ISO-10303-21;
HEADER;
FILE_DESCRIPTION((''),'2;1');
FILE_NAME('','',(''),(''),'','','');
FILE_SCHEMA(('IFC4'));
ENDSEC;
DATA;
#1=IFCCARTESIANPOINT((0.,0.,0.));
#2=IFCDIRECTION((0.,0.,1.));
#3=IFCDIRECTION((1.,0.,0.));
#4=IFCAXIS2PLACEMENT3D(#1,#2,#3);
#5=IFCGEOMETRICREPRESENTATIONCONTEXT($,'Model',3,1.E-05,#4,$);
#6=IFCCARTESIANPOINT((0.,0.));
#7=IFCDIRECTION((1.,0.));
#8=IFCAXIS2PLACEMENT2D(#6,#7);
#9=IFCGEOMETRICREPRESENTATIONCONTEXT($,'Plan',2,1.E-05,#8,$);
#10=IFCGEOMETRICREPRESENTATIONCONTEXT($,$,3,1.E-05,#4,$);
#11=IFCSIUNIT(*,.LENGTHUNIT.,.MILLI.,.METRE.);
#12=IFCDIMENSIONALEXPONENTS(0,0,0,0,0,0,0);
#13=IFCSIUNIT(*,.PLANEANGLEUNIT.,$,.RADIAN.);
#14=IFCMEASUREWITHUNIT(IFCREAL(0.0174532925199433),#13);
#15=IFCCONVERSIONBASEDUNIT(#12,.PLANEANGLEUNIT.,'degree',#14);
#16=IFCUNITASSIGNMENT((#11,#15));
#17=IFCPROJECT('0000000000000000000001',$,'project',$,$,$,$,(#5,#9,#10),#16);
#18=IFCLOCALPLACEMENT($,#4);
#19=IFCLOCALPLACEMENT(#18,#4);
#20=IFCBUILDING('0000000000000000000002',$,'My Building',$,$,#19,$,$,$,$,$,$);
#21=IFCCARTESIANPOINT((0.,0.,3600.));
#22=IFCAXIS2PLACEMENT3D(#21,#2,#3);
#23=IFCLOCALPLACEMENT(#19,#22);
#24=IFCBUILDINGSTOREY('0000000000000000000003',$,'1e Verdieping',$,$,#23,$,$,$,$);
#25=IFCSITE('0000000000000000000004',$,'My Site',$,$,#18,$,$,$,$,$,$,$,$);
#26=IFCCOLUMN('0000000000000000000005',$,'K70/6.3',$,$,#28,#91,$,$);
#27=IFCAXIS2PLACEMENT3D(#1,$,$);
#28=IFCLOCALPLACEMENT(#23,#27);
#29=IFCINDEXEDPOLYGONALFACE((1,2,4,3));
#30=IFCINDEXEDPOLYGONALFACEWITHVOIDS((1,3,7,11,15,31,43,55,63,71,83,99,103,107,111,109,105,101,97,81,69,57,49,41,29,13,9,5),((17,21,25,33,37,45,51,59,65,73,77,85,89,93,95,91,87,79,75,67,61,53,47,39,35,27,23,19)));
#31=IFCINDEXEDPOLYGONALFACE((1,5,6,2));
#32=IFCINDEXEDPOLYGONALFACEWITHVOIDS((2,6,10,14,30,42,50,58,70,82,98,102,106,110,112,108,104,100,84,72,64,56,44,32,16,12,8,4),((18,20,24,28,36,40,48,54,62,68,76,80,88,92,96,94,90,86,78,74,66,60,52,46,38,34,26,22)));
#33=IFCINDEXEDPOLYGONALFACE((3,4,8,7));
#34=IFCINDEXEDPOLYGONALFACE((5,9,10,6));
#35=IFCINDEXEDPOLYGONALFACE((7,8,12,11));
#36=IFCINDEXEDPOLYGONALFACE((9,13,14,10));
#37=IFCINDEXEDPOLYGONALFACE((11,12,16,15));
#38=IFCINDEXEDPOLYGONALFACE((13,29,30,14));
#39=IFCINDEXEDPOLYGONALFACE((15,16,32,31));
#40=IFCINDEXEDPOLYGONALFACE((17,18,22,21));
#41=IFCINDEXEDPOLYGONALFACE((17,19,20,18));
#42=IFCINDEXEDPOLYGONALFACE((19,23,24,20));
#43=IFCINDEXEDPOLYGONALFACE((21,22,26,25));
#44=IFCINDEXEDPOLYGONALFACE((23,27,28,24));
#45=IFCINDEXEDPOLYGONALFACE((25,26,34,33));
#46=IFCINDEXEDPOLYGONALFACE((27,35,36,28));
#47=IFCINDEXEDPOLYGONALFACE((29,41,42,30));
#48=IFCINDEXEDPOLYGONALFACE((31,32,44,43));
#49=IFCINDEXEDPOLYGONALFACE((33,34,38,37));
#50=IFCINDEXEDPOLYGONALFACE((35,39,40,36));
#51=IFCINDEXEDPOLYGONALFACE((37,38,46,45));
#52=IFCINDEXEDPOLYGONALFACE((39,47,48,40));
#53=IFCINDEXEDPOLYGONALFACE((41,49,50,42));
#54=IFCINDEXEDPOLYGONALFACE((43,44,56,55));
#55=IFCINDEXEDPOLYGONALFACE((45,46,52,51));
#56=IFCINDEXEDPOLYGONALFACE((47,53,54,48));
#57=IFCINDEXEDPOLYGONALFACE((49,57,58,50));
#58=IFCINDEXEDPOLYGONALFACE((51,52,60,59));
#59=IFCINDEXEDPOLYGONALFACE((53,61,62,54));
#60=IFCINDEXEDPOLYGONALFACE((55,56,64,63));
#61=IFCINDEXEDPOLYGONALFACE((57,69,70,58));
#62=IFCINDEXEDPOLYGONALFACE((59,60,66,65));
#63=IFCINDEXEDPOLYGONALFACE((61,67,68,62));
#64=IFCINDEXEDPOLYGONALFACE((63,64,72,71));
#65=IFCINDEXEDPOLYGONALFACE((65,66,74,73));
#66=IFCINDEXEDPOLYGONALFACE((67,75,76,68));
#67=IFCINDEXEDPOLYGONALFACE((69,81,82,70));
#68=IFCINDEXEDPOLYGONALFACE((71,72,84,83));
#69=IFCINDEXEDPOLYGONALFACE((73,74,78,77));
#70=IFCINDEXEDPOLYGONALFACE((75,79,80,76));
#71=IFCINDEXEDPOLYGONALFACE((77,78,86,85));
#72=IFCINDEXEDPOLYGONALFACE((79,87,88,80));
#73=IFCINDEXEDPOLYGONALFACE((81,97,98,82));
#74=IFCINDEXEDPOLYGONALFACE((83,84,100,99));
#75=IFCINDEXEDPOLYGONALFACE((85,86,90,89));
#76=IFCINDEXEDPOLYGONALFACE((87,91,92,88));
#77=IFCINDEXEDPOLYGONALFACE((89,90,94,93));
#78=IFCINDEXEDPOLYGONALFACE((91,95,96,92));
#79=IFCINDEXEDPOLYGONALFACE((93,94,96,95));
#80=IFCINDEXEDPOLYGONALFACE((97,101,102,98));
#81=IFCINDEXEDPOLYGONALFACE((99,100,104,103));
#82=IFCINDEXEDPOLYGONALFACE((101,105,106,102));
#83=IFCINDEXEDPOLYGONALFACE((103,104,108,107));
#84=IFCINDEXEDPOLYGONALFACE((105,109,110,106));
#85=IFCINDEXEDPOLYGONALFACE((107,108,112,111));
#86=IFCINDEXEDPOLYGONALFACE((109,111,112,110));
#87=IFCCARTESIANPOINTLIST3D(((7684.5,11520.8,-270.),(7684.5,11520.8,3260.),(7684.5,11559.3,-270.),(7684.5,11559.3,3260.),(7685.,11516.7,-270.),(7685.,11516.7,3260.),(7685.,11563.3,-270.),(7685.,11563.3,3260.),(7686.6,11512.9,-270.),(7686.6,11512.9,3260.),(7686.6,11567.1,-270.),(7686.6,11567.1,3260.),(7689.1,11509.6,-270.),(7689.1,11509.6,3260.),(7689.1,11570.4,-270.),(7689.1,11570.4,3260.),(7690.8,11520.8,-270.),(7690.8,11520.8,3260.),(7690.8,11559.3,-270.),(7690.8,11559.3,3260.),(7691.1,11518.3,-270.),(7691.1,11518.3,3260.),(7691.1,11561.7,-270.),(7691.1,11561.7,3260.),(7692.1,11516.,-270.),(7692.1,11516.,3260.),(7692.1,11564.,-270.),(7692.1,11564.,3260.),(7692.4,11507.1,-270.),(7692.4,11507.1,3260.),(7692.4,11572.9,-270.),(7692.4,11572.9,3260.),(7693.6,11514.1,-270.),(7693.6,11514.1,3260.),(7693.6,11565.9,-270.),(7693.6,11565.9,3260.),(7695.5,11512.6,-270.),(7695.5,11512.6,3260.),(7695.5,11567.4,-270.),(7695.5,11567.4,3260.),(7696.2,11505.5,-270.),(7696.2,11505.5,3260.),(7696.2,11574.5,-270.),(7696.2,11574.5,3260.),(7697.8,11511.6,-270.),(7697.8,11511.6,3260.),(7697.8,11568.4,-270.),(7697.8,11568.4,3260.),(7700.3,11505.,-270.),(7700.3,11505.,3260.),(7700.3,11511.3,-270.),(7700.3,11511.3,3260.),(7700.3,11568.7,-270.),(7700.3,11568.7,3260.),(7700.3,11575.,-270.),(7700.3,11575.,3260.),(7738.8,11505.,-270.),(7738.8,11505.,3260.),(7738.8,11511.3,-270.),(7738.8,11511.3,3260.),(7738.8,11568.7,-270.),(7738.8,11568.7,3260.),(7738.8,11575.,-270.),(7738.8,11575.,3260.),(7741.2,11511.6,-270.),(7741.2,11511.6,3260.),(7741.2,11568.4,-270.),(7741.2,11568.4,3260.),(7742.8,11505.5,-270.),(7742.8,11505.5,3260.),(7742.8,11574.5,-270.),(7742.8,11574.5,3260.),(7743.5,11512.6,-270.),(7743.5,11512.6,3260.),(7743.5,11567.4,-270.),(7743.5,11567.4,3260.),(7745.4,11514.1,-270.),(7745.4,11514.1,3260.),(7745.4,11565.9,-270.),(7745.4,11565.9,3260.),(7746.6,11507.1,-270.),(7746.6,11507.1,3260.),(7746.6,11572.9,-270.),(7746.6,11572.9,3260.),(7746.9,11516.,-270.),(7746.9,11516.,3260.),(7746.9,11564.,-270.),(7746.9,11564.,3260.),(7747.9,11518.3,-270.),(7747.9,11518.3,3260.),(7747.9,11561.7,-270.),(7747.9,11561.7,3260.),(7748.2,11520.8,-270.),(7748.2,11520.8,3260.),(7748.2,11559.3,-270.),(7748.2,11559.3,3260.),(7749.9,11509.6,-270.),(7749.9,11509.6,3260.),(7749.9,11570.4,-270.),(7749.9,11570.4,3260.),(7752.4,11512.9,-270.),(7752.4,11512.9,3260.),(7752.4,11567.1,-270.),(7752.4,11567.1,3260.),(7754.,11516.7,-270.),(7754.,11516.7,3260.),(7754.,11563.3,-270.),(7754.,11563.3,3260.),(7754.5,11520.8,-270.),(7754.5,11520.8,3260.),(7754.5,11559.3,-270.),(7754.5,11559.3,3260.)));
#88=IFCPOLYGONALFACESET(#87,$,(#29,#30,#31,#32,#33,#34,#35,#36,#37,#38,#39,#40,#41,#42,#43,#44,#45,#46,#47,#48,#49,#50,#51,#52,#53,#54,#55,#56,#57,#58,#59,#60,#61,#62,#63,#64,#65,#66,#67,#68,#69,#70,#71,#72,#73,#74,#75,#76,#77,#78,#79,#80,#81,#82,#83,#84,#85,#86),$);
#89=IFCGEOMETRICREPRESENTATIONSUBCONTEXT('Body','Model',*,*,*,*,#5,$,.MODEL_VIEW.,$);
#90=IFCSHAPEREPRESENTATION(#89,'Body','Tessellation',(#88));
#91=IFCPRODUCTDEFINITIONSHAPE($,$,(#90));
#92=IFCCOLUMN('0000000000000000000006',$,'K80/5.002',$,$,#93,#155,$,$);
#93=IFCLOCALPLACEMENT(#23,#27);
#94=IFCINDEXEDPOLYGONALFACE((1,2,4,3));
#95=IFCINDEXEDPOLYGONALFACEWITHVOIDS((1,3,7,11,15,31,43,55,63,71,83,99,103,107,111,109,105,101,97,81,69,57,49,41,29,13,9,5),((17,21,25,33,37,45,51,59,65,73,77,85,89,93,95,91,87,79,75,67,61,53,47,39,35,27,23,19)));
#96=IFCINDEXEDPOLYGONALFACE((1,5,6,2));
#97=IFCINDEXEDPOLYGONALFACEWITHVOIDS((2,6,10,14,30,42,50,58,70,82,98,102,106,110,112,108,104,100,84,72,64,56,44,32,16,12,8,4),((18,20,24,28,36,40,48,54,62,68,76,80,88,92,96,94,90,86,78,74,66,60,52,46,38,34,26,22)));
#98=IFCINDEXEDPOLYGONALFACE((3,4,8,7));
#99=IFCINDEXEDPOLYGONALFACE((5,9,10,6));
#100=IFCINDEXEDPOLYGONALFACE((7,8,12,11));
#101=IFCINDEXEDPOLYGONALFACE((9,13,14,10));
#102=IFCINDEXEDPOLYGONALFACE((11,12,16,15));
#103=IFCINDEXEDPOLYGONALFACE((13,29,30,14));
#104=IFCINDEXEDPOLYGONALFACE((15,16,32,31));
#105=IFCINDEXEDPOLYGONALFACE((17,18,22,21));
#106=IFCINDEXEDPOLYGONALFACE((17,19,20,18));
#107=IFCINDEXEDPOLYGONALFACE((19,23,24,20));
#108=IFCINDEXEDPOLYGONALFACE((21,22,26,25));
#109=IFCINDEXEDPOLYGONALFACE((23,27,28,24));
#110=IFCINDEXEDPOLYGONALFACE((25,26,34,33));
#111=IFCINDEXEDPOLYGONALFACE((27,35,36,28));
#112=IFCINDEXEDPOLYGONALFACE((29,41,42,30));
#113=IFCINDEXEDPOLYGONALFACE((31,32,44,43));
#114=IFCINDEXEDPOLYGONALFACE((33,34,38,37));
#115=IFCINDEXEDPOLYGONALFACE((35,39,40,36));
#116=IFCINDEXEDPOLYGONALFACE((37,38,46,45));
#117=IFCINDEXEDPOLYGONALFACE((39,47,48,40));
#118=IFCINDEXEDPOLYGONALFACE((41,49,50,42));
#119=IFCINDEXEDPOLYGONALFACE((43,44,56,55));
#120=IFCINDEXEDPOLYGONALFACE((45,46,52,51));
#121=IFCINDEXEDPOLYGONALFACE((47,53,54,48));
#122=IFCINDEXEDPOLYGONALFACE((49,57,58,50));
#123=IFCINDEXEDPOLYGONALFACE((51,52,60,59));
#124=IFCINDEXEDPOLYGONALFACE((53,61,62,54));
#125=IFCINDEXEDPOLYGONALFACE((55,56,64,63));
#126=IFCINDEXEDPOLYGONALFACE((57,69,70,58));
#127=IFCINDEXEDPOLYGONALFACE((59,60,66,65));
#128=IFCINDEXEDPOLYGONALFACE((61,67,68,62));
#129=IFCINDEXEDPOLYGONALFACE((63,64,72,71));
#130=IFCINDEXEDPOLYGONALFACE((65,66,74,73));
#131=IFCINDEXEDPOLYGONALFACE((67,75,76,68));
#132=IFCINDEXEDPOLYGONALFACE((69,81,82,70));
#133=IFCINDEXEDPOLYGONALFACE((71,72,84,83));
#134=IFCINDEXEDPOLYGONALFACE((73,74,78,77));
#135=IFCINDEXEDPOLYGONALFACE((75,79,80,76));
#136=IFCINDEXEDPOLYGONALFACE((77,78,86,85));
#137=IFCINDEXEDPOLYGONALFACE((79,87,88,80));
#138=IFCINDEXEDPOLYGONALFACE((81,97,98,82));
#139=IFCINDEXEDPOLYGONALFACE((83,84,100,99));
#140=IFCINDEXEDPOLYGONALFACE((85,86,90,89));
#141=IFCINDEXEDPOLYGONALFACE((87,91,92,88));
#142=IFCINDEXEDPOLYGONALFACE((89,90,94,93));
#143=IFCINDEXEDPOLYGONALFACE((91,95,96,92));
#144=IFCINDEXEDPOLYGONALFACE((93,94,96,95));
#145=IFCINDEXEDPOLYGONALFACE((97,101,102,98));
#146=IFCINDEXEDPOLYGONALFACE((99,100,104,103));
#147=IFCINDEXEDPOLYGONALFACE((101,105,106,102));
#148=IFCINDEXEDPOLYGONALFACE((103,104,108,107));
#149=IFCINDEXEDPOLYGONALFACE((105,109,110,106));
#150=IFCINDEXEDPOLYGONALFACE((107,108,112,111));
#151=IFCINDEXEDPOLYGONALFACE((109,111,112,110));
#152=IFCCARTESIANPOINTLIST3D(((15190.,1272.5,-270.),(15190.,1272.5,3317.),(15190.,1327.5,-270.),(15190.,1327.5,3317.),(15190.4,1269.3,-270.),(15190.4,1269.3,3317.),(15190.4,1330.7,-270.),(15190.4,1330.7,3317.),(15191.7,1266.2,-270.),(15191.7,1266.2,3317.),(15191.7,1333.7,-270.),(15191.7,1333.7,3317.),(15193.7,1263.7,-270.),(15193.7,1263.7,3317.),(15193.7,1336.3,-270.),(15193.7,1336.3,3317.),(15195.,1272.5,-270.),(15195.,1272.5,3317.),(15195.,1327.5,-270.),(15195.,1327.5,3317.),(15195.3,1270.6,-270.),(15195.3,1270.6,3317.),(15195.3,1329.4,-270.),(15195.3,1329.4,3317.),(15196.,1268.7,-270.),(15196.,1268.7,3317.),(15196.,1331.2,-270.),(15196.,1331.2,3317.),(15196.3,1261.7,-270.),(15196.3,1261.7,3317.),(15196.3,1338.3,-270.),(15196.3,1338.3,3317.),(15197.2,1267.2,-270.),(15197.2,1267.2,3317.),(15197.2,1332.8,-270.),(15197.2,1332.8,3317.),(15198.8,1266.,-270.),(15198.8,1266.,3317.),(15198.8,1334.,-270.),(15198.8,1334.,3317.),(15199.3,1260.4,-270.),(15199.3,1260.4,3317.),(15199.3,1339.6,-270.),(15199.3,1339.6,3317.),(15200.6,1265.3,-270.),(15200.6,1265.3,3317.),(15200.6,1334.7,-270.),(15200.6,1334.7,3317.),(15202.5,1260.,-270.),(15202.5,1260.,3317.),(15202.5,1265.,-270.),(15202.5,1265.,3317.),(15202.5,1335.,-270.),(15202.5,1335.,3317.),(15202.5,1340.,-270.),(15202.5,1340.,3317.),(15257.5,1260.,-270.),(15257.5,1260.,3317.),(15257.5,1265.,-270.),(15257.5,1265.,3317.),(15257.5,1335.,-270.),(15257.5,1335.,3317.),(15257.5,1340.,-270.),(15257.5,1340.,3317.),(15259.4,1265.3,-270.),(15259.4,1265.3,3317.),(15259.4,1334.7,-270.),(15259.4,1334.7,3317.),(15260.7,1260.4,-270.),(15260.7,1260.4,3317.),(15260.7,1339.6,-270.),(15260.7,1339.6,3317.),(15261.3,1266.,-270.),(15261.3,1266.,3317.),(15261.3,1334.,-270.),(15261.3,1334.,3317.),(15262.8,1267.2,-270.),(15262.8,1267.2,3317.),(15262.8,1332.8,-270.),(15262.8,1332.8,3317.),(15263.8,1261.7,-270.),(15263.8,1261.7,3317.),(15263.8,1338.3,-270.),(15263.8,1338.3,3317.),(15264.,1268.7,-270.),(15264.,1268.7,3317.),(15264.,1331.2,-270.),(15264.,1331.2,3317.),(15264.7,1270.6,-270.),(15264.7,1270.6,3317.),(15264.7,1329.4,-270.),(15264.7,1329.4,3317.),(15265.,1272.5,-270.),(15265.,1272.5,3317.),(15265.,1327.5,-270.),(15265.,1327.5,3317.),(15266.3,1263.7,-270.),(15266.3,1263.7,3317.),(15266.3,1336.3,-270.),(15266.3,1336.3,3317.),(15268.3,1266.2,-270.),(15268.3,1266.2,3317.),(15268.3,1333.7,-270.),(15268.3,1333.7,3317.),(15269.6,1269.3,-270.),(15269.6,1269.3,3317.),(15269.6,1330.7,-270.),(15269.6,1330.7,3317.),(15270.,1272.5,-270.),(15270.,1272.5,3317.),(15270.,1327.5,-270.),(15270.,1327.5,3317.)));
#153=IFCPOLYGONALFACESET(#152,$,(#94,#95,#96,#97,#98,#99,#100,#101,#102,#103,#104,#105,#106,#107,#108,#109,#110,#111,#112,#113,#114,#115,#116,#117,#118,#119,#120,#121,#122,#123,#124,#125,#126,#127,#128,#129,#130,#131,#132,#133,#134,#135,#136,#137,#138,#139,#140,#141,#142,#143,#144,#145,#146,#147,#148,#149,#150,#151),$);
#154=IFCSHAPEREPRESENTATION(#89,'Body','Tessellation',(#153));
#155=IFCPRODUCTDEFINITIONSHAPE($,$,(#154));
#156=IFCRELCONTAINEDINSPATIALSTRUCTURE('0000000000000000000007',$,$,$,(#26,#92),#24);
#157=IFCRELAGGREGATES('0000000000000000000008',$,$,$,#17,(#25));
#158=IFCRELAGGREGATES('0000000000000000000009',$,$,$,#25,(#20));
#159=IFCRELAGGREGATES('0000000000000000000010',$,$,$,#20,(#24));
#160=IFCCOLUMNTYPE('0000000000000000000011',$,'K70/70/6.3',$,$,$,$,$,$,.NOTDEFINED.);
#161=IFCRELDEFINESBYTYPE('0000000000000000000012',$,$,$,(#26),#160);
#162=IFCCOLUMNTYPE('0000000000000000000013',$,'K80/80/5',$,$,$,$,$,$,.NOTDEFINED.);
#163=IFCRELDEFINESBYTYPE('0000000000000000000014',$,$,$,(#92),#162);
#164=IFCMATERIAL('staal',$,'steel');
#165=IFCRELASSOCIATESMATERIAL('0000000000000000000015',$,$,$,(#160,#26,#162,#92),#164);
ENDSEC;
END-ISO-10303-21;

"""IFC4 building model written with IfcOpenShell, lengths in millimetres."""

from ifc_helpers import new_model, entity, si_unit, converted_unit, frame, origin_with_axes, origin_2d_with_axis, place, context, subcontext, project, spatial, hollow_rectangle, extrude, material, material_profile, profile_set, profile_usage, type_object, element, save


model = new_model("IFC4")

# Units and contexts
model_context = context("Model", 3, precision=1e-05, world=origin_with_axes())
plan_context = context("Plan", 2, precision=1e-05, world=origin_2d_with_axis())
context_of_model = context(None, 3, precision=1e-05, world=origin_with_axes())
body_context = subcontext(model_context, "Body", "Model", "MODEL_VIEW")
ifc_project = project(units=[si_unit("LENGTHUNIT", "METRE", prefix="MILLI"), converted_unit("PLANEANGLEUNIT", "degree", entity("IfcReal", 0.0174532925199433), si_unit("PLANEANGLEUNIT", "RADIAN"), dimensions=[0, 0, 0, 0, 0, 0, 0])], contexts=[model_context, plan_context, context_of_model])

# Site, building, storey
site_placement = place(None, origin_with_axes())
site = spatial("IfcSite", under=ifc_project, at=site_placement, Name="My Site")
building_placement = place(site_placement, origin_with_axes())
building = spatial("IfcBuilding", under=site, at=building_placement, Name="My Building")
storey_placement = place(building_placement, frame((0.0, 0.0, 3600.0), z_axis=(0.0, 0.0, 1.0), x_axis=(1.0, 0.0, 0.0)))
storey = spatial("IfcBuildingStorey", under=building, at=storey_placement, Name="1e Verdieping")

# Columns
ifc_material = material(Name="staal", Category="steel")
ifc_material_profile_1 = material_profile(ifc_material, hollow_rectangle(XDim=70.0, YDim=70.0, WallThickness=6.3, InnerFilletRadius=9.4, OuterFilletRadius=15.8))
ifc_profile_set_1 = profile_set([ifc_material_profile_1], Name="K70/70/6.3")
column_type_1 = type_object("IfcColumnType", Name="K70/70/6.3", PredefinedType="NOTDEFINED", material=ifc_profile_set_1)
ifc_profile_usage_1 = profile_usage(ifc_profile_set_1)
column_1_placement = place(storey_placement, frame((7719.5, 11540.0, -270.0), z_axis=(0.0, 0.0, 1.0), x_axis=(1.0, 0.0, 0.0)))
element("IfcColumn", 1, at=column_1_placement, inside=storey, type_object=column_type_1, material=ifc_profile_usage_1, Name="K70/6.3", context=body_context, shape_type="SweptSolid", body=[
    extrude(hollow_rectangle(XDim=70.0, YDim=70.0, WallThickness=6.3, InnerFilletRadius=9.4, OuterFilletRadius=15.8), origin_with_axes(), (0.0, 0.0, 1.0), 3530.0),
])
ifc_material_profile_2 = material_profile(ifc_material, hollow_rectangle(XDim=80.0, YDim=80.0, WallThickness=5.0, InnerFilletRadius=7.5, OuterFilletRadius=12.5))
ifc_profile_set_2 = profile_set([ifc_material_profile_2], Name="K80/80/5")
ifc_profile_usage_2 = profile_usage(ifc_profile_set_2)
column_type_2 = type_object("IfcColumnType", Name="K80/80/5", PredefinedType="NOTDEFINED", material=ifc_profile_set_2)
column_2_placement = place(storey_placement, frame((15230.0, 1300.0, -270.0), z_axis=(0.0, 0.0, 1.0), x_axis=(1.0, 0.0, 0.0)))
element("IfcColumn", 2, at=column_2_placement, inside=storey, type_object=column_type_2, material=ifc_profile_usage_2, Name="K80/5.002", context=body_context, shape_type="SweptSolid", body=[
    extrude(hollow_rectangle(XDim=80.0, YDim=80.0, WallThickness=5.0, InnerFilletRadius=7.5, OuterFilletRadius=12.5), origin_with_axes(), (0.0, 0.0, 1.0), 3587.0),
])

save(model, "model.ifc")
